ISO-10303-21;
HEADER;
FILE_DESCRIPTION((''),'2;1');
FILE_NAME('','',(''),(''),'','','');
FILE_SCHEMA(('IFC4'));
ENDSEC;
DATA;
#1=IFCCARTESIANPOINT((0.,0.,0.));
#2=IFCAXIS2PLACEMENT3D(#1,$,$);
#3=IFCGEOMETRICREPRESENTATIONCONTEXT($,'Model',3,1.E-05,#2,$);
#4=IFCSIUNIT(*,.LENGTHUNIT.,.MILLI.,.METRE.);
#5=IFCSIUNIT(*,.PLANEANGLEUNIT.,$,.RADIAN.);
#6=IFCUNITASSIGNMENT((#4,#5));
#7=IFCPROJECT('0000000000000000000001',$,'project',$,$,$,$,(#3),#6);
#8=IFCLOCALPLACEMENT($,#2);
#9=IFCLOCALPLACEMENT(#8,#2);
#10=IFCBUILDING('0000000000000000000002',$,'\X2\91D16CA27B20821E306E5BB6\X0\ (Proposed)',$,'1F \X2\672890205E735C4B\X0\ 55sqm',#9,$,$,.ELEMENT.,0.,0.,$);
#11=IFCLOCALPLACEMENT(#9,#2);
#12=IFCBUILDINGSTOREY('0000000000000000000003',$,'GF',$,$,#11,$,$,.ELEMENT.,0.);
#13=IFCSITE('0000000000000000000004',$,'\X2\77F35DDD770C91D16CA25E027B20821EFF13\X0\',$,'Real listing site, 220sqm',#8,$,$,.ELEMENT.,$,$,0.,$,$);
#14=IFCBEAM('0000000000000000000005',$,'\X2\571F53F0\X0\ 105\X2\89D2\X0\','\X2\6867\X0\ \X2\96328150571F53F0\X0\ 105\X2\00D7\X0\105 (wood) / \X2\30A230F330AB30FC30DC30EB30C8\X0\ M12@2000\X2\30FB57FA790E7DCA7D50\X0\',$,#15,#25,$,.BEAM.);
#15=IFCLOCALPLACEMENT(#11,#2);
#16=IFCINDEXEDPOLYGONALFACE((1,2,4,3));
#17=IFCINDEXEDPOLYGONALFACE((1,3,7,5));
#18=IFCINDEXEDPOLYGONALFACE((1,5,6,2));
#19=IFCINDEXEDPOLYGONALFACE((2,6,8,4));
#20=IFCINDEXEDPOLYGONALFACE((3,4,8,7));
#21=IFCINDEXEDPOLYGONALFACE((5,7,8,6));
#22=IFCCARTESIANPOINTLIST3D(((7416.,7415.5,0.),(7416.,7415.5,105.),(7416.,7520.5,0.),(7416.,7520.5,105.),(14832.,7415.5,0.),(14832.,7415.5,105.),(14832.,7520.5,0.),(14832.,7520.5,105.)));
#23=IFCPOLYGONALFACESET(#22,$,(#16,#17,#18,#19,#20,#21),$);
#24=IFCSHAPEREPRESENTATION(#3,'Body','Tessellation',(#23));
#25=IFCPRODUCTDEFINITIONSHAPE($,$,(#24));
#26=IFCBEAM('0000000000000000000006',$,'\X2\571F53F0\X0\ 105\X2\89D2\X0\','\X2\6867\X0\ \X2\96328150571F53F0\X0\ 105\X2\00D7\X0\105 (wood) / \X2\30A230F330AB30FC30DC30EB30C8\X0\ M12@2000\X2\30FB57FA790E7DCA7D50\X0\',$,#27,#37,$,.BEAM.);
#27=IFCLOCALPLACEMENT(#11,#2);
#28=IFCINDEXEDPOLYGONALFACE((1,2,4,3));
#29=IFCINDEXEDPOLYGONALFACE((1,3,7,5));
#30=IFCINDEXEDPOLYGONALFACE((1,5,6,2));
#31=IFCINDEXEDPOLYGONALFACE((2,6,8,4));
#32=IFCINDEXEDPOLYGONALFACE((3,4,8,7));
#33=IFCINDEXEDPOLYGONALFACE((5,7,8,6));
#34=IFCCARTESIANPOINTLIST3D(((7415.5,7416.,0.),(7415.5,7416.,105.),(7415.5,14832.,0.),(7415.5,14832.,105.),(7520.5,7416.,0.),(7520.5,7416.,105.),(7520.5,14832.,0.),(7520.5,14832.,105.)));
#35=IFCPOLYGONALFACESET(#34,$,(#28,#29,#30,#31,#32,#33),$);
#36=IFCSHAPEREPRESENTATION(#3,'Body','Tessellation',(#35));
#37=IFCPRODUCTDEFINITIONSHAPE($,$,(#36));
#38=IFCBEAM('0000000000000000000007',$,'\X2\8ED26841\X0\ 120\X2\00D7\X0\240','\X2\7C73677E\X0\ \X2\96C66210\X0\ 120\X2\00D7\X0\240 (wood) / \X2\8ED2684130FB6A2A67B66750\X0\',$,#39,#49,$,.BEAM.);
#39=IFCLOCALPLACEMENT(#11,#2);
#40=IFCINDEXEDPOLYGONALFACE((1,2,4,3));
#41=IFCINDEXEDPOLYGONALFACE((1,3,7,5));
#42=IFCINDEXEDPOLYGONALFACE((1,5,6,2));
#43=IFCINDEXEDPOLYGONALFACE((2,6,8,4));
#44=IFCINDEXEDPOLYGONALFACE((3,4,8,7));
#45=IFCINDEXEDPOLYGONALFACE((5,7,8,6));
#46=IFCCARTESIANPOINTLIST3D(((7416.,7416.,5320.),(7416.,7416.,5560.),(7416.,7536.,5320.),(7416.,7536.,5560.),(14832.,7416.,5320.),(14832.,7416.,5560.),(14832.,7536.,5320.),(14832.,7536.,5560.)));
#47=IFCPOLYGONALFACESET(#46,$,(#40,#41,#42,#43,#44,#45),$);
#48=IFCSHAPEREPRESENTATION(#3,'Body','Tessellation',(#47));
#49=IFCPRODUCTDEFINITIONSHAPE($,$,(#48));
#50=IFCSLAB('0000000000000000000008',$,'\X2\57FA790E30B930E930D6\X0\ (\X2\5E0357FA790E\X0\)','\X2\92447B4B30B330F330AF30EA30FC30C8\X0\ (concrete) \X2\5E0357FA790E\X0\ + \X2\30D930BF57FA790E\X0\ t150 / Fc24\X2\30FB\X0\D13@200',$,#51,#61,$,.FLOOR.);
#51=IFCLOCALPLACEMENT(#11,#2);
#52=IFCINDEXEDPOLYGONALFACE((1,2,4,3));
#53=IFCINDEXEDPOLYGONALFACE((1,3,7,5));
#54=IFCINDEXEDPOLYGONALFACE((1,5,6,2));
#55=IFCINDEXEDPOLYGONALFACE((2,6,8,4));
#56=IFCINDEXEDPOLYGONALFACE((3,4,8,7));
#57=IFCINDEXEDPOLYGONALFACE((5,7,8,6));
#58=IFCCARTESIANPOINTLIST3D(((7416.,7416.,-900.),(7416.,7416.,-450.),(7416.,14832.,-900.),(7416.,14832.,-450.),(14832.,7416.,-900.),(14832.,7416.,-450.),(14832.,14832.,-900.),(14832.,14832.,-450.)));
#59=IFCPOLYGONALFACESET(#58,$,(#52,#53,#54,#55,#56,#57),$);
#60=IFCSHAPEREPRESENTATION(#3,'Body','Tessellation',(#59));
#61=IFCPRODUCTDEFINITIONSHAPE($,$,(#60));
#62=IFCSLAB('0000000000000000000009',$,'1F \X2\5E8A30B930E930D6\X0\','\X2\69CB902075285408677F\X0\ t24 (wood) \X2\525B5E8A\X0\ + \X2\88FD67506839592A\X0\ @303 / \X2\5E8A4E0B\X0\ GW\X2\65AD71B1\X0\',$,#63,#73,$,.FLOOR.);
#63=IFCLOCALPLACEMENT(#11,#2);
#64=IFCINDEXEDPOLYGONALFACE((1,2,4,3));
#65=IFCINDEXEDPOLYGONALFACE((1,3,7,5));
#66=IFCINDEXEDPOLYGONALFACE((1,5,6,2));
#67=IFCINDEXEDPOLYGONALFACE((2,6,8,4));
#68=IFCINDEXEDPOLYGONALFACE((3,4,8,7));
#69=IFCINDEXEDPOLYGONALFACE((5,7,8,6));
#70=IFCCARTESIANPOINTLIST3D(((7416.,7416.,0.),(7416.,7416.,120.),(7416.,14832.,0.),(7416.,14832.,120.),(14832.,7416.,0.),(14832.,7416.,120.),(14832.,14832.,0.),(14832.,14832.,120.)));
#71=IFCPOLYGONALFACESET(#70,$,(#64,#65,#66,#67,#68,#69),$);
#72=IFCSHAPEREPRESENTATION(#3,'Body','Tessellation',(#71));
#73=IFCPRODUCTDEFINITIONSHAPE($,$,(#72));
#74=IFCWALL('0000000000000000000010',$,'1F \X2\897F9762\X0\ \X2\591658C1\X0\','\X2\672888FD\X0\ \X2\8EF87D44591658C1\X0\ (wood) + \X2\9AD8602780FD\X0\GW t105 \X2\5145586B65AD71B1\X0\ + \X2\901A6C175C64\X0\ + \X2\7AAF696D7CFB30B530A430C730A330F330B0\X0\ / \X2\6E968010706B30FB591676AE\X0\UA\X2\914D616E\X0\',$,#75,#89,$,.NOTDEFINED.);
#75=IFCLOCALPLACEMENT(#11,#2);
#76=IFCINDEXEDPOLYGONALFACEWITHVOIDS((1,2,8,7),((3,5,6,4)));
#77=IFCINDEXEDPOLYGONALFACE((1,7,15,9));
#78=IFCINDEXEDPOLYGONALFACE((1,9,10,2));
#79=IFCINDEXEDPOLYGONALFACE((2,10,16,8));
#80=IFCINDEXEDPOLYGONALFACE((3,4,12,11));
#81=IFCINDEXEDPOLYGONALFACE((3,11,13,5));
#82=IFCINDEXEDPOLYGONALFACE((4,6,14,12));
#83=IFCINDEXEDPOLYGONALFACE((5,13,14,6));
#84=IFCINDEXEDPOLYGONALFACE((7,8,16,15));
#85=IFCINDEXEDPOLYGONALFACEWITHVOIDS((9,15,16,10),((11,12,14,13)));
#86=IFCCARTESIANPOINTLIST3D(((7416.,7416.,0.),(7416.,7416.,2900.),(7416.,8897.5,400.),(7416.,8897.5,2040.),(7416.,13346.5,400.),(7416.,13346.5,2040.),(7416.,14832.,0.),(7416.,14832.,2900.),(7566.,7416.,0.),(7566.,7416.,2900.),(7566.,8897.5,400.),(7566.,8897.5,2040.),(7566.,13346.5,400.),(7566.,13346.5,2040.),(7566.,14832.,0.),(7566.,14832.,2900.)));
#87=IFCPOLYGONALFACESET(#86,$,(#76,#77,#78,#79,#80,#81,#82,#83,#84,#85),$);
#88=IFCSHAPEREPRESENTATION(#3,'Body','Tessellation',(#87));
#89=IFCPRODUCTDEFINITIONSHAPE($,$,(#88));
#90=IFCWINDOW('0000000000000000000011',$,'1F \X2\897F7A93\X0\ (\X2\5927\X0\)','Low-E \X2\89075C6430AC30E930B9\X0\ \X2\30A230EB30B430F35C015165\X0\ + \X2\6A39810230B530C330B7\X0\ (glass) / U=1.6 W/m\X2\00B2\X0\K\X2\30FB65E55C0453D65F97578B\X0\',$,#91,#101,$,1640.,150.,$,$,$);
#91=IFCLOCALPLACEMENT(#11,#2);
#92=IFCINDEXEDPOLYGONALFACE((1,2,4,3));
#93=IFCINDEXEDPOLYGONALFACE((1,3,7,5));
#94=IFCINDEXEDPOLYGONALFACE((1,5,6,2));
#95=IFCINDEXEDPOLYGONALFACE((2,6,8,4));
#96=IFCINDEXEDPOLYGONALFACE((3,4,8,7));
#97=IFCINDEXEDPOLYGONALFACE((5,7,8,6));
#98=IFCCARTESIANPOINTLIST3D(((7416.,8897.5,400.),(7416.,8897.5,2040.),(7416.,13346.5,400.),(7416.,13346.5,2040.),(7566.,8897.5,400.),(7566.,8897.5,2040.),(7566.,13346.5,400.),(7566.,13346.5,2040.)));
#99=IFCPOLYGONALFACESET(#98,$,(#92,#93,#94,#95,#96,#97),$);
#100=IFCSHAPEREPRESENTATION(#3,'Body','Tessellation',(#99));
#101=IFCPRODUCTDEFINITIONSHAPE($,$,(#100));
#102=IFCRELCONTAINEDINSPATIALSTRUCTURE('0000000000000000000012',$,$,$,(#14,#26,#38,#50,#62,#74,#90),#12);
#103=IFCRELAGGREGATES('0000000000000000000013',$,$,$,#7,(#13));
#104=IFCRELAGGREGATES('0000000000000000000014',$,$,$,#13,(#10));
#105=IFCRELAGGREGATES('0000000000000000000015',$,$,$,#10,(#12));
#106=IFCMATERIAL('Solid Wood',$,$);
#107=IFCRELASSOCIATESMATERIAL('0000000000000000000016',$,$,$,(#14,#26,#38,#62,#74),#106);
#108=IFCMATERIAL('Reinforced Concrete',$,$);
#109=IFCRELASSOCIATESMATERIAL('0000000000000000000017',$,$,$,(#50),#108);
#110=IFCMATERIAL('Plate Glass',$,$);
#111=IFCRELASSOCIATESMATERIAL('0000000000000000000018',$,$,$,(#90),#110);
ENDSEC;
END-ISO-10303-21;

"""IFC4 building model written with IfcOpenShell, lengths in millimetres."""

from ifc_helpers import new_model, si_unit, frame, frame_2d, origin, place, context, project, spatial, rectangle, extrude, material, element, fill, save


model = new_model("IFC4")

# Units and contexts
model_context = context("Model", 3, precision=1e-05, world=origin())
ifc_project = project(units=[si_unit("LENGTHUNIT", "METRE", prefix="MILLI"), si_unit("PLANEANGLEUNIT", "RADIAN")], contexts=[model_context])

# Site, building, storey
site_placement = place(None, origin())
site = spatial("IfcSite", under=ifc_project, at=site_placement, Name="石川県金沢市笠舞３", ObjectType="Real listing site, 220sqm", CompositionType="ELEMENT", RefElevation=0.0)
building_placement = place(site_placement, origin())
building = spatial("IfcBuilding", under=site, at=building_placement, Name="金沢笠舞の家 (Proposed)", ObjectType="1F 木造平屋 55sqm", CompositionType="ELEMENT", ElevationOfRefHeight=0.0, ElevationOfTerrain=0.0)
storey_placement = place(building_placement, origin())
storey = spatial("IfcBuildingStorey", under=building, at=storey_placement, Name="GF", CompositionType="ELEMENT", Elevation=0.0)

# Shared definitions
ifc_material_1 = material(Name="Solid Wood")

# Beams
beam_1_placement = place(storey_placement, frame((3708.0, 3708.0, 0.0)))
element("IfcBeam", 1, at=beam_1_placement, inside=storey, material=ifc_material_1, Name="土台 105角", Description="桧 防腐土台 105×105 (wood) / アンカーボルト M12@2000・基礎緊結", PredefinedType="BEAM", context=model_context, shape_type="SweptSolid", body=[
    extrude(rectangle(XDim=7416.0, YDim=105.0, at=frame_2d((3708.0, 52.0))), frame((3708.0, 3708.0, 0.0)), (0.0, 0.0, 1.0), 105.0),
])
beam_2_placement = place(storey_placement, frame((3708.0, 3708.0, 0.0)))
element("IfcBeam", 2, at=beam_2_placement, inside=storey, material=ifc_material_1, Name="土台 105角", Description="桧 防腐土台 105×105 (wood) / アンカーボルト M12@2000・基礎緊結", PredefinedType="BEAM", context=model_context, shape_type="SweptSolid", body=[
    extrude(rectangle(XDim=105.0, YDim=7416.0, at=frame_2d((52.0, 3708.0))), frame((3708.0, 3708.0, 0.0)), (0.0, 0.0, 1.0), 105.0),
])
beam_3_placement = place(storey_placement, frame((3708.0, 3708.0, 2660.0)))
element("IfcBeam", 3, at=beam_3_placement, inside=storey, material=ifc_material_1, Name="軒桁 120×240", Description="米松 集成 120×240 (wood) / 軒桁・横架材", PredefinedType="BEAM", context=model_context, shape_type="SweptSolid", body=[
    extrude(rectangle(XDim=7416.0, YDim=120.0, at=frame_2d((3708.0, 60.0))), frame((3708.0, 3708.0, 2660.0)), (0.0, 0.0, 1.0), 240.0),
])

# Slabs
ifc_material_2 = material(Name="Reinforced Concrete")
slab_1_placement = place(storey_placement, frame((3708.0, 3708.0, -450.0)))
element("IfcSlab", 4, at=slab_1_placement, inside=storey, material=ifc_material_2, Name="基礎スラブ (布基礎)", Description="鉄筋コンクリート (concrete) 布基礎 + ベタ基礎 t150 / Fc24・D13@200", PredefinedType="FLOOR", context=model_context, shape_type="SweptSolid", body=[
    extrude(rectangle(XDim=7416.0, YDim=7416.0, at=frame_2d((3708.0, 3708.0))), frame((3708.0, 3708.0, -450.0)), (0.0, 0.0, 1.0), 450.0),
])
slab_2_placement = place(storey_placement, frame((3708.0, 3708.0, 0.0)))
element("IfcSlab", 5, at=slab_2_placement, inside=storey, material=ifc_material_1, Name="1F 床スラブ", Description="構造用合板 t24 (wood) 剛床 + 製材根太 @303 / 床下 GW断熱", PredefinedType="FLOOR", context=model_context, shape_type="SweptSolid", body=[
    extrude(rectangle(XDim=7416.0, YDim=7416.0, at=frame_2d((3708.0, 3708.0))), frame((3708.0, 3708.0, 0.0)), (0.0, 0.0, 1.0), 120.0),
])

# Shared definitions
ifc_material_3 = material(Name="Plate Glass")

# Wall, opening, window
wall_1_placement = place(storey_placement, frame((3708.0, 3708.0, 0.0)))
wall_1 = element("IfcWall", 6, at=wall_1_placement, inside=storey, material=ifc_material_1, Name="1F 西面 外壁", Description="木製 軸組外壁 (wood) + 高性能GW t105 充填断熱 + 通気層 + 窯業系サイディング / 準耐火・外皮UA配慮", PredefinedType="NOTDEFINED", context=model_context, shape_type="SweptSolid", body=[
    extrude(rectangle(XDim=150.0, YDim=7416.0, at=frame_2d((75.0, 3708.0))), frame((3708.0, 3708.0, 0.0)), (0.0, 0.0, 1.0), 2900.0),
])
opening_1_placement = place(storey_placement, frame((3708.0, 4449.0, 200.0)))
opening_1 = element("IfcOpeningElement", 7, at=opening_1_placement, cuts=wall_1, PredefinedType="NOTDEFINED", context=model_context, shape_type="SweptSolid", body=[
    extrude(rectangle(XDim=150.0, YDim=4449.0, at=frame_2d((75.0, 2224.0))), frame((3708.0, 4449.0, 200.0)), (0.0, 0.0, 1.0), 1640.0),
])
window_1_placement = place(storey_placement, frame((3708.0, 4449.0, 200.0)))
window_1 = element("IfcWindow", 8, at=window_1_placement, inside=storey, material=ifc_material_3, Name="1F 西窓 (大)", Description="Low-E 複層ガラス アルゴン封入 + 樹脂サッシ (glass) / U=1.6 W/m²K・日射取得型", OverallHeight=1640.0, OverallWidth=150.0, context=model_context, shape_type="SweptSolid", body=[
    extrude(rectangle(XDim=150.0, YDim=4449.0, at=frame_2d((75.0, 2224.0))), frame((3708.0, 4449.0, 200.0)), (0.0, 0.0, 1.0), 1640.0),
])
fill(opening_1, window_1)

save(model, "model.ifc")
